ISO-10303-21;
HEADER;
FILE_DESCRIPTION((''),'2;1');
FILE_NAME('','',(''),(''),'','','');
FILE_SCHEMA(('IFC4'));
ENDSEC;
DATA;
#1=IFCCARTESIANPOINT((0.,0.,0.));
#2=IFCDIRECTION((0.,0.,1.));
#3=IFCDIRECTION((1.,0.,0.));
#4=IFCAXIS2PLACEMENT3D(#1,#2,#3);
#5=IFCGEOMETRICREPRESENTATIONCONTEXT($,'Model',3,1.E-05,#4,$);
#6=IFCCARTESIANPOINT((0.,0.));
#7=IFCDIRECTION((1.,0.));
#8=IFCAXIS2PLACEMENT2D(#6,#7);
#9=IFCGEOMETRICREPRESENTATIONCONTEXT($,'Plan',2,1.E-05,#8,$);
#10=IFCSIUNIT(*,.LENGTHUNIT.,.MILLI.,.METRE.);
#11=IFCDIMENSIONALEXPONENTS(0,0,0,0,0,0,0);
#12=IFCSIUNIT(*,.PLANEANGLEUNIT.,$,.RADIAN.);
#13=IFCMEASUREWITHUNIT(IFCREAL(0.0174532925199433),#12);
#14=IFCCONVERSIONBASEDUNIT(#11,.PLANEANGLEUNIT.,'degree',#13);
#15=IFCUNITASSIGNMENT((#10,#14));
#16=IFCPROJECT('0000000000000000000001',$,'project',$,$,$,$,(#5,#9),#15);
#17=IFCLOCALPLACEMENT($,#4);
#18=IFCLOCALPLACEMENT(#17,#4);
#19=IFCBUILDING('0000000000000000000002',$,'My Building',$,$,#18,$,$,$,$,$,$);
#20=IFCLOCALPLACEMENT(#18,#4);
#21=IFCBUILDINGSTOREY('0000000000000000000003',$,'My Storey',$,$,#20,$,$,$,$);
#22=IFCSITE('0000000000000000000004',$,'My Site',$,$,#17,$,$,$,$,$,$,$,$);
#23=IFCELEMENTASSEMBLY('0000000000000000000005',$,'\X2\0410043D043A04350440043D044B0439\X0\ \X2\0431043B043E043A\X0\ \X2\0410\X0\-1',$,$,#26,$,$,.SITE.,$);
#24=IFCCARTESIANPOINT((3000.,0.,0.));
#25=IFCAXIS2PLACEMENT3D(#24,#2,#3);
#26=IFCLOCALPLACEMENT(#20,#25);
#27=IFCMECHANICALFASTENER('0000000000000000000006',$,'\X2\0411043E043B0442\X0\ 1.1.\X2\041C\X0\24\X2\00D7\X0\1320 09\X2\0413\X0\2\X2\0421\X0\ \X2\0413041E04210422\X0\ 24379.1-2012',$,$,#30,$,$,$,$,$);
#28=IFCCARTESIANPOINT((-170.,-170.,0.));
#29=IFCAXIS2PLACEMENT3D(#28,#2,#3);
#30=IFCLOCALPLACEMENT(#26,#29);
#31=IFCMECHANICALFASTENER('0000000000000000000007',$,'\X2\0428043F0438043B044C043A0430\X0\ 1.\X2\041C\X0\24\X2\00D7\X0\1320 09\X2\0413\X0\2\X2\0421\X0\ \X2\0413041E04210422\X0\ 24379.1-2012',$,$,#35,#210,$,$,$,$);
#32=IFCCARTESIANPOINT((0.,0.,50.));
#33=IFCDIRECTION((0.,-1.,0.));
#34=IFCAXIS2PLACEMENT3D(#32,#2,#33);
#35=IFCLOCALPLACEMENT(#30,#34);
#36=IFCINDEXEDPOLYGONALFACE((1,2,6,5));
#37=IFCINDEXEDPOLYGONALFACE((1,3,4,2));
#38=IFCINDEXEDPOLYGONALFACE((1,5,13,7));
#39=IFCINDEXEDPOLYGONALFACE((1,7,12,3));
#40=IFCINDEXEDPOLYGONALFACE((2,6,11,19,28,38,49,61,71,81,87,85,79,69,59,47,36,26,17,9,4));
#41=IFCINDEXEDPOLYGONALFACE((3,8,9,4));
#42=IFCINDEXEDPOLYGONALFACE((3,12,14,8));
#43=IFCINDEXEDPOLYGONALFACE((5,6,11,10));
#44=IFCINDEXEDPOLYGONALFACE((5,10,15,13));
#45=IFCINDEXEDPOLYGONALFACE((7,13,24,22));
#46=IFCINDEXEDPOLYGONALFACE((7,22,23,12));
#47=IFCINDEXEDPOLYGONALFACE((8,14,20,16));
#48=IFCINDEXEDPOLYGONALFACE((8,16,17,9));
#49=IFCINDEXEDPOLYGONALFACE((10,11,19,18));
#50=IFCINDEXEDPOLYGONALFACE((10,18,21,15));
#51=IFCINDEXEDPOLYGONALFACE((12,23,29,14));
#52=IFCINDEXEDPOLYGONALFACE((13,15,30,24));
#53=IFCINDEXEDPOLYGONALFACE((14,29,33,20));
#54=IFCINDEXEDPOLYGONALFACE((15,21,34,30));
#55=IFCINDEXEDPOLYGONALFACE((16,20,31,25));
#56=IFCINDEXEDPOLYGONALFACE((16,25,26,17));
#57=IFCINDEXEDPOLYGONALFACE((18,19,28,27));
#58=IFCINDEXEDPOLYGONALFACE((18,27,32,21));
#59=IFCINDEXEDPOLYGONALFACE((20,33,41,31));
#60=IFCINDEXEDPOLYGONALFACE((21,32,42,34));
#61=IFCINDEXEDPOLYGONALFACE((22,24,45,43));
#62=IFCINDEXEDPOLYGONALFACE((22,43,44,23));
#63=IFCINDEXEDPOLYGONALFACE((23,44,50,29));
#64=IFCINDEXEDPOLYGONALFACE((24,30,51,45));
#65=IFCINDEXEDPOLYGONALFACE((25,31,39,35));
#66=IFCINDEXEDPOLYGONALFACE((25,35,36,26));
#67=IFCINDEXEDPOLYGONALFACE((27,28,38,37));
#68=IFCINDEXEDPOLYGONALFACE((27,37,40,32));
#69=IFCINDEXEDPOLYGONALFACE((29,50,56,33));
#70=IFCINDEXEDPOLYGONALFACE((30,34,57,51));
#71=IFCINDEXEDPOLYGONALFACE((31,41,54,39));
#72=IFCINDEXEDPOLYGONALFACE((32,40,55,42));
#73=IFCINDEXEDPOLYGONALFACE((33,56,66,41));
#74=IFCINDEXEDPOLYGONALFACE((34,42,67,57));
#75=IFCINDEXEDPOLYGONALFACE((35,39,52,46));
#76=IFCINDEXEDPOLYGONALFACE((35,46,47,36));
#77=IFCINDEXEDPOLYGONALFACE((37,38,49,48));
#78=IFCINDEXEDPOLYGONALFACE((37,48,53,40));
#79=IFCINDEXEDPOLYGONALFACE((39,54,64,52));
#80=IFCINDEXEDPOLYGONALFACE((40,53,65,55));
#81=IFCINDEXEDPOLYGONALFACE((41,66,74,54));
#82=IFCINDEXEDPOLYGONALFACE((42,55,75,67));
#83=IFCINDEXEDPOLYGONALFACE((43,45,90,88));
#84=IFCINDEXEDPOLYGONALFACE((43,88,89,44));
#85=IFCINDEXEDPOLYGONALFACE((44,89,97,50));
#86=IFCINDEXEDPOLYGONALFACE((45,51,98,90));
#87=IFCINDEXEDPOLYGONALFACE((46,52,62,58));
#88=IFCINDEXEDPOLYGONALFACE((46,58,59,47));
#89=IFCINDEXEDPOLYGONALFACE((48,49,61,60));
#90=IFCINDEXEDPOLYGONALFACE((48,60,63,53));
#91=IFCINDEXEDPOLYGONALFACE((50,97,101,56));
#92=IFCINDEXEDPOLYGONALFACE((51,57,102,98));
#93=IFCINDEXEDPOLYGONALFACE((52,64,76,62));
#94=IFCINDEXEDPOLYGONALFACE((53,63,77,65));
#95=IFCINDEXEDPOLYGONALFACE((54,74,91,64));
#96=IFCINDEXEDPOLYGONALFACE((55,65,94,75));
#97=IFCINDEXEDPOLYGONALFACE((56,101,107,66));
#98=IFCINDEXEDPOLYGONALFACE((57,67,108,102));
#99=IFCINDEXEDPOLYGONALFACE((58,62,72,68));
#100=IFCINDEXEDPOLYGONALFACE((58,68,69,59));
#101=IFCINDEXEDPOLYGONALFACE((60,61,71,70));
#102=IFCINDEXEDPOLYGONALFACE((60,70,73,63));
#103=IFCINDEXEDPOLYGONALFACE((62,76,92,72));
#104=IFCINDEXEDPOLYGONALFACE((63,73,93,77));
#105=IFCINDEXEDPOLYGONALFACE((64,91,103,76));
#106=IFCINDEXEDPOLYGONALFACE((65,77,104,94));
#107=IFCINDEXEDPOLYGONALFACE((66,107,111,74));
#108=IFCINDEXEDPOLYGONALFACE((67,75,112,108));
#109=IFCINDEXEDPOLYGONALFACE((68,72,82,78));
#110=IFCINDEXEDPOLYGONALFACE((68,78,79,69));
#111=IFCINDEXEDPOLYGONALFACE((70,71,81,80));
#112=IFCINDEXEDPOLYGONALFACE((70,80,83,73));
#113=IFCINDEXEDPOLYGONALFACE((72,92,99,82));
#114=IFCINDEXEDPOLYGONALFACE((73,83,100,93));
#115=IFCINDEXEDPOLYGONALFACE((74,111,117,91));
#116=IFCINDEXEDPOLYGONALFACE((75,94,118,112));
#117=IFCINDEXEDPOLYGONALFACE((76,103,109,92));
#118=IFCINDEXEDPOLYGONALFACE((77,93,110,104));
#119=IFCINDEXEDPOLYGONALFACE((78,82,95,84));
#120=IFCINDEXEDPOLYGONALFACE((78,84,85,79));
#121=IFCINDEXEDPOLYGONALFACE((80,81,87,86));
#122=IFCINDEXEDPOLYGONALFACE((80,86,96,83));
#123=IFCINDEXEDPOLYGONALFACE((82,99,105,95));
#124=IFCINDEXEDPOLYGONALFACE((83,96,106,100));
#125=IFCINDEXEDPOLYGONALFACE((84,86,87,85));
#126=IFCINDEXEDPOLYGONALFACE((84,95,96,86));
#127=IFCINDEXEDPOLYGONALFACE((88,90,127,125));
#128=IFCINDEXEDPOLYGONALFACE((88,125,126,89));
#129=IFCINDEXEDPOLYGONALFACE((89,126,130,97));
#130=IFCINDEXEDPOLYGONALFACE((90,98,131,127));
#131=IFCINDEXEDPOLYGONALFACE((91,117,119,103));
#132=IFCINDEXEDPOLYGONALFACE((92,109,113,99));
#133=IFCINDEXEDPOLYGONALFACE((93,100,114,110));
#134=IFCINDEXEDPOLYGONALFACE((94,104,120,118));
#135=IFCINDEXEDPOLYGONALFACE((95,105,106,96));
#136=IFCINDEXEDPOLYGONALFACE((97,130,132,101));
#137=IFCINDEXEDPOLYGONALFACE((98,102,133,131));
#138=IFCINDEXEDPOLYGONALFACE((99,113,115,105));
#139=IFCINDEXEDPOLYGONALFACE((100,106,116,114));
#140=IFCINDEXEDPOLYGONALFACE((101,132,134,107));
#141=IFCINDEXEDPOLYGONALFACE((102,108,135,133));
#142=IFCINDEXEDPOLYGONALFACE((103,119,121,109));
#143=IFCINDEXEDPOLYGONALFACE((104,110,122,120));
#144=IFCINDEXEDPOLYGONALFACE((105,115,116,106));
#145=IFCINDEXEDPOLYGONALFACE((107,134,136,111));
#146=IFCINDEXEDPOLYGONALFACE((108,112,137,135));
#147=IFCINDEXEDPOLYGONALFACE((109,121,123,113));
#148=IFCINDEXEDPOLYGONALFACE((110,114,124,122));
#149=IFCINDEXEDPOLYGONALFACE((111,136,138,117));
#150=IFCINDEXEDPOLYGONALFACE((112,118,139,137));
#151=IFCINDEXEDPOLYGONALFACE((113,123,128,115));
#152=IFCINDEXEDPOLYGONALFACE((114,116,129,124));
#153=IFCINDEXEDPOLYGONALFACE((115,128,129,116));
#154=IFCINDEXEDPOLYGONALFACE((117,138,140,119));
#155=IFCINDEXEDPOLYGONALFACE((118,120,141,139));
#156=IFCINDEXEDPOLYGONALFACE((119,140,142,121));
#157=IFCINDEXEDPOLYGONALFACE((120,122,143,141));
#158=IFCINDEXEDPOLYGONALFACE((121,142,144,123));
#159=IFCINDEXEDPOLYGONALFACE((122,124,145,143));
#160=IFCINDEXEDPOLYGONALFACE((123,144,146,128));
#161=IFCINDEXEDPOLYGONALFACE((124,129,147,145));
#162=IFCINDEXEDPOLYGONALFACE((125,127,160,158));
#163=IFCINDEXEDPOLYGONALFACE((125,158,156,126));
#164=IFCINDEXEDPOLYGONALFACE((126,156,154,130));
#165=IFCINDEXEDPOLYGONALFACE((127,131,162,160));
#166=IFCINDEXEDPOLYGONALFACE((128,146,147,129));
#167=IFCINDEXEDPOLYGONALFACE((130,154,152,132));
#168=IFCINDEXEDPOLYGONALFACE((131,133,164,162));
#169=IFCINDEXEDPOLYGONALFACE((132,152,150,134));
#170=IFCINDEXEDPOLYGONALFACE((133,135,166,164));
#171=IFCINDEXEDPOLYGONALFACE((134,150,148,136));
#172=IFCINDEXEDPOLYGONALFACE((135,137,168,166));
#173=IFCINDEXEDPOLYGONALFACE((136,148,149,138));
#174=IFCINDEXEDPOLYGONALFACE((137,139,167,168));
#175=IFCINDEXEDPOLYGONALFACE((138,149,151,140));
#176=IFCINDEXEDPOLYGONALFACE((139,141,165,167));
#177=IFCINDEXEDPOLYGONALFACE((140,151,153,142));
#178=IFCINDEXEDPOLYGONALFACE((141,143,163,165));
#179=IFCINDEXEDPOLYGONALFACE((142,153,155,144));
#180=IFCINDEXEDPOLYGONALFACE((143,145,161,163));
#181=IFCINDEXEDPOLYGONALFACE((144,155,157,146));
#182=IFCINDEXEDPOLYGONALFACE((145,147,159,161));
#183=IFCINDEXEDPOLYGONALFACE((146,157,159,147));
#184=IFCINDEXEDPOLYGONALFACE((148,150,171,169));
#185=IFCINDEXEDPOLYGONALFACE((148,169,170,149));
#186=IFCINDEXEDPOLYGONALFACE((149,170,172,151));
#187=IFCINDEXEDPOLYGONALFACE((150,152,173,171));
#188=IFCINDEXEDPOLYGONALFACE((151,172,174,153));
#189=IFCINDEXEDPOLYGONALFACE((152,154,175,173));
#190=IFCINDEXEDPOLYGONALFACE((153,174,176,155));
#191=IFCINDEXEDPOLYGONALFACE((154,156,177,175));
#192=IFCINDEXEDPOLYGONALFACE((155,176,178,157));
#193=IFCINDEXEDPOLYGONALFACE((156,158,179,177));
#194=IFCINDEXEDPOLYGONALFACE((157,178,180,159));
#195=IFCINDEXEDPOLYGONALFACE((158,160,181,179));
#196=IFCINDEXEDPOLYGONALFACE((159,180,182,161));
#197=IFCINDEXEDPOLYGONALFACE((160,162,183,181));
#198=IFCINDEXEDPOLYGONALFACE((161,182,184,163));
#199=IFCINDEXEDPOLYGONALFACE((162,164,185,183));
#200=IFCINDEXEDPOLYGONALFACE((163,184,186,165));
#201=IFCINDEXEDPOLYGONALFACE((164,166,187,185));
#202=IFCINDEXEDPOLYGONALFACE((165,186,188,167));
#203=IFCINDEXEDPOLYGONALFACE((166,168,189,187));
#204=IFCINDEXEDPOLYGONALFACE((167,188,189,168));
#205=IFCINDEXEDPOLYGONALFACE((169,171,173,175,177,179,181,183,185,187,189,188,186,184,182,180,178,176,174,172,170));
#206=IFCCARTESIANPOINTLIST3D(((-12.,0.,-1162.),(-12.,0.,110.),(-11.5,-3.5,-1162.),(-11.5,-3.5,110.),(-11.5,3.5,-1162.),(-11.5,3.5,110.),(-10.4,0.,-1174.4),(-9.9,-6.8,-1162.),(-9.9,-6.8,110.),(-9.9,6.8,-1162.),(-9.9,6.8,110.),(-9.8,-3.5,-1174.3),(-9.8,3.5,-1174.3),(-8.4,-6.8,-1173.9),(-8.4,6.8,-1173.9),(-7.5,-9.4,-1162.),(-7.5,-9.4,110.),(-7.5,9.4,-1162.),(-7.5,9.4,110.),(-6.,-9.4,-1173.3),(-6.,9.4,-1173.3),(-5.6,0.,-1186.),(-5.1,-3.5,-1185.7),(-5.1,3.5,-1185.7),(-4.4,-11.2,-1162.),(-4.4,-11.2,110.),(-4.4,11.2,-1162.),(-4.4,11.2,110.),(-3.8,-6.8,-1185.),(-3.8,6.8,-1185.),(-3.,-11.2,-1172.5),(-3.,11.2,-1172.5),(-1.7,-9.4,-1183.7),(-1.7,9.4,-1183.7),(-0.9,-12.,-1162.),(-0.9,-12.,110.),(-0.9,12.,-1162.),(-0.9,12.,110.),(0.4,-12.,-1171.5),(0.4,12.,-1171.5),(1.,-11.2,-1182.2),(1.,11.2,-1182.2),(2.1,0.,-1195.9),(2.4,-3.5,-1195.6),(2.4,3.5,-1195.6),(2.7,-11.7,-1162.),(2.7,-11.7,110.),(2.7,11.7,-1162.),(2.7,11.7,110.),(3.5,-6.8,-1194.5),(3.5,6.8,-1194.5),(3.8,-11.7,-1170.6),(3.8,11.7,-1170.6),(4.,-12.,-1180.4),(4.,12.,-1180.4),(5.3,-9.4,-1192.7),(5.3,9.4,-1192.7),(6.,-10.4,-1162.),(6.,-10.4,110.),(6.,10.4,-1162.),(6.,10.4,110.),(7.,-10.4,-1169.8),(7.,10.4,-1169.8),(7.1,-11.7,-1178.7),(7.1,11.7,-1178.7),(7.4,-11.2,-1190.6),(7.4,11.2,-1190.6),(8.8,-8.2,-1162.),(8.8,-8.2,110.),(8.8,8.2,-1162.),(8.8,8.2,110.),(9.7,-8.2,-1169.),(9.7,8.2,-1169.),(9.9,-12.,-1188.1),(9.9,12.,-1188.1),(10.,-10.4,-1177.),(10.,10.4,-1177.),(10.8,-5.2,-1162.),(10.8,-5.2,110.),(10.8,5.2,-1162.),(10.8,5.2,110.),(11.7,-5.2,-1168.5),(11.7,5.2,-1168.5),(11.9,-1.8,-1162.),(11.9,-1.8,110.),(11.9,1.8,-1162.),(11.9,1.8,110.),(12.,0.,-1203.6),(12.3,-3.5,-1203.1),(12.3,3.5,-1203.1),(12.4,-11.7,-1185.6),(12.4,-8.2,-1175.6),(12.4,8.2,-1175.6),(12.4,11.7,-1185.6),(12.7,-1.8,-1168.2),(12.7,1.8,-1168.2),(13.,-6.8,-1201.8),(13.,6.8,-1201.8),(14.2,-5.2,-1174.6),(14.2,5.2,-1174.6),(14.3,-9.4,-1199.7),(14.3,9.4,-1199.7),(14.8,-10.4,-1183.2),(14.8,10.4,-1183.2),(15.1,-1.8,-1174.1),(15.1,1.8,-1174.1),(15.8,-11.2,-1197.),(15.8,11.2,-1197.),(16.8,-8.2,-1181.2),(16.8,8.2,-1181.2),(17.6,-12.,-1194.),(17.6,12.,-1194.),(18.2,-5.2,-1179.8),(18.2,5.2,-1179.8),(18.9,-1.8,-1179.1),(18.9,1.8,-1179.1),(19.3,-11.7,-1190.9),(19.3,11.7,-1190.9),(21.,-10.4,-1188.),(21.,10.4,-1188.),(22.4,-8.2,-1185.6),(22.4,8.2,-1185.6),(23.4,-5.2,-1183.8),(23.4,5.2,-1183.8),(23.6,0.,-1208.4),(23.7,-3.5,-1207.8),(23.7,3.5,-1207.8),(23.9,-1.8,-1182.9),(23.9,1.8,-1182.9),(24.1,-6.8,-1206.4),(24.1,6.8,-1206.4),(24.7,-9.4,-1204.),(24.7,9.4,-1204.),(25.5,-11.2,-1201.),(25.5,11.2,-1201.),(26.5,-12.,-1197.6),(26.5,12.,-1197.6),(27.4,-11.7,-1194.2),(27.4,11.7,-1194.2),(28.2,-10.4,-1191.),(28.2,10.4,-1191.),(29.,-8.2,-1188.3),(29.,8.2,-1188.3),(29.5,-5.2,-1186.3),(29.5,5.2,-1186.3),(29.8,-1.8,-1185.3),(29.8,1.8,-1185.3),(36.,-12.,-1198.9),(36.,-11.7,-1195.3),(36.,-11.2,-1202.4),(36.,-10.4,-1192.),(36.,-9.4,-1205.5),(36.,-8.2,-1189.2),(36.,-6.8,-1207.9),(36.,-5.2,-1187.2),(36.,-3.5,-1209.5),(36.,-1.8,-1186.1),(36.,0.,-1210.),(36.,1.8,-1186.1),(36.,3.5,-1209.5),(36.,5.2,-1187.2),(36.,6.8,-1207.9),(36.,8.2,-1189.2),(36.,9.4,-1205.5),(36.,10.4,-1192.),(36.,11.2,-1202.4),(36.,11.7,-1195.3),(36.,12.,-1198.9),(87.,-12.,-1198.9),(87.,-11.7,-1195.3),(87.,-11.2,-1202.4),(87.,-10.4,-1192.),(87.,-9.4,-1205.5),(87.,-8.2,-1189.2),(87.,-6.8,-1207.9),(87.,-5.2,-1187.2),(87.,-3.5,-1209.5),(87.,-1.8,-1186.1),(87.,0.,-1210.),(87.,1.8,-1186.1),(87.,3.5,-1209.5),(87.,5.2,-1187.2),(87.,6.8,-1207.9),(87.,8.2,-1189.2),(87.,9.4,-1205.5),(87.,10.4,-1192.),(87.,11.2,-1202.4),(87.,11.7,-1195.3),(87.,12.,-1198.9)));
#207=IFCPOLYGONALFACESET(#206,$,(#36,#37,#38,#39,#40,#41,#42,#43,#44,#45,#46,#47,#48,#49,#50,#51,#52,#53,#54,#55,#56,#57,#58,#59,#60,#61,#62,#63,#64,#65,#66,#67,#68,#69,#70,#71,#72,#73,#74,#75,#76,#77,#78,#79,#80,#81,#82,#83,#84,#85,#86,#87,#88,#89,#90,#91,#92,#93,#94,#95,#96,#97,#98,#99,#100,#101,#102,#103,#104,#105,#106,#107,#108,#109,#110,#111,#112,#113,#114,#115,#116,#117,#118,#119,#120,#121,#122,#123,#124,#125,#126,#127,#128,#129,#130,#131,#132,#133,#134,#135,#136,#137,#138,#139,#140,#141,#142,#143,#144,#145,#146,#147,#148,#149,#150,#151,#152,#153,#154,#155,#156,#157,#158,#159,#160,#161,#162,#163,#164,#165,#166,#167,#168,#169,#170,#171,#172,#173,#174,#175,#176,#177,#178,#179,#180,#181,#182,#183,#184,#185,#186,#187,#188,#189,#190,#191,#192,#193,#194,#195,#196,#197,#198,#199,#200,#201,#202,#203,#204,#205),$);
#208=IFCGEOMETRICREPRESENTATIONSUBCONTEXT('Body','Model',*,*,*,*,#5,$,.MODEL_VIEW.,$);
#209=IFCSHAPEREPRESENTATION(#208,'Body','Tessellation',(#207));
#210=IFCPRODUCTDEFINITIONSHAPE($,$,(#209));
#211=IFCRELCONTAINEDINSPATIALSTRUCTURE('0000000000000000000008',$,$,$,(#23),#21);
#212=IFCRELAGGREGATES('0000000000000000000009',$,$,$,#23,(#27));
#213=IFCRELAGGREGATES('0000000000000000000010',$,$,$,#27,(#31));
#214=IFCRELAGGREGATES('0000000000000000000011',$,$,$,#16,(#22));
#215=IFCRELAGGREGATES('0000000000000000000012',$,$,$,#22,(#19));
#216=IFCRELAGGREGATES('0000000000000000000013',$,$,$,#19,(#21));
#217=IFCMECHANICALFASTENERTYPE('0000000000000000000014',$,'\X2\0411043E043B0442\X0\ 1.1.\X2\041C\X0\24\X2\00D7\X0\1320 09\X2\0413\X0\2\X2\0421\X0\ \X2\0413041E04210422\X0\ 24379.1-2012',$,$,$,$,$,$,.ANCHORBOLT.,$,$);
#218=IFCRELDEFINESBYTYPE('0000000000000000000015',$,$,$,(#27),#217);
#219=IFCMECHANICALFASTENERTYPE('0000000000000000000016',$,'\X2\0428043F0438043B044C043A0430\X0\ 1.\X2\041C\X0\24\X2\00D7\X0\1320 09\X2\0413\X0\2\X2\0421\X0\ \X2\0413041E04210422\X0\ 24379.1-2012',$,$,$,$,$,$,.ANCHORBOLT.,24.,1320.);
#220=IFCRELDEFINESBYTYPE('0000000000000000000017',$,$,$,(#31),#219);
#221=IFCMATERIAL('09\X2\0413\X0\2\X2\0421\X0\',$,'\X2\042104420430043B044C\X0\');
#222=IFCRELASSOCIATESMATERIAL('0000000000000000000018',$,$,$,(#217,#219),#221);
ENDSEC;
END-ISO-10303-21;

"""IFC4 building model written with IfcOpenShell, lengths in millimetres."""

from ifc_helpers import new_model, entity, si_unit, converted_unit, frame, origin_with_axes, origin_2d_with_axis, place, context, subcontext, project, spatial, source, transform, mapped, material, type_object, type_shapes, element, aggregate, save


model = new_model("IFC4")

# Units and contexts
model_context = context("Model", 3, precision=1e-05, world=origin_with_axes())
plan_context = context("Plan", 2, precision=1e-05, world=origin_2d_with_axis())
body_context = subcontext(model_context, "Body", "Model", "MODEL_VIEW")
ifc_project = project(units=[si_unit("LENGTHUNIT", "METRE", prefix="MILLI"), converted_unit("PLANEANGLEUNIT", "degree", entity("IfcReal", 0.0174532925199433), si_unit("PLANEANGLEUNIT", "RADIAN"), dimensions=[0, 0, 0, 0, 0, 0, 0])], contexts=[model_context, plan_context])

# Site, building, storey
site_placement = place(None, origin_with_axes())
site = spatial("IfcSite", under=ifc_project, at=site_placement, Name="My Site")
building_placement = place(site_placement, origin_with_axes())
building = spatial("IfcBuilding", under=site, at=building_placement, Name="My Building")
storey_placement = place(building_placement, origin_with_axes())
storey = spatial("IfcBuildingStorey", under=building, at=storey_placement, Name="My Storey")

# Element assembly
placement_1 = place(storey_placement, frame((3000.0, 0.0, 0.0), z_axis=(0.0, 0.0, 1.0), x_axis=(1.0, 0.0, 0.0)))
assembly_1 = element("IfcElementAssembly", 1, at=placement_1, inside=storey, Name="Анкерный блок А-1", AssemblyPlace="SITE")

# Shared definitions
ifc_material_1 = material(Name="09Г2С", Category="Сталь")
mechanical_fastener_type_1 = type_object("IfcMechanicalFastenerType", Name="Болт 1.1.М24×1320 09Г2С ГОСТ 24379.1-2012", PredefinedType="ANCHORBOLT", material=ifc_material_1)
mechanical_fastener_type_2 = type_object("IfcMechanicalFastenerType", Name="Шпилька 1.М24×1320 09Г2С ГОСТ 24379.1-2012", NominalDiameter=24.0, NominalLength=1320.0, PredefinedType="ANCHORBOLT", material=ifc_material_1)
shared_shape_1 = source(frame((0.0, 0.0, 110.0), z_axis=(0.0, 0.0, 1.0), x_axis=(1.0, 0.0, 0.0)), body_context, "Body", "AdvancedSweptSolid", [
    entity("IfcSweptDiskSolid", entity("IfcIndexedPolyCurve", entity("IfcCartesianPointList3D", [[0.0, 0.0, 0.0], [0.0, 0.0, -1272.0], [10.5, 0.0, -1297.5], [36.0, 0.0, -1308.0], [87.0, 0.0, -1308.0]]), [entity("IfcLineIndex", [1, 2]), entity("IfcArcIndex", [2, 3, 4]), entity("IfcLineIndex", [4, 5])]), 12.0),
])
type_shapes(mechanical_fastener_type_2, [shared_shape_1])

# Mechanical fasteners
mechanical_fastener_1_placement = place(placement_1, frame((-170.0, -170.0, 0.0), z_axis=(0.0, 0.0, 1.0), x_axis=(1.0, 0.0, 0.0)))
mechanical_fastener_1 = element("IfcMechanicalFastener", 2, at=mechanical_fastener_1_placement, type_object=mechanical_fastener_type_1, Name="Болт 1.1.М24×1320 09Г2С ГОСТ 24379.1-2012")
mechanical_fastener_2_placement = place(mechanical_fastener_1_placement, frame((0.0, 0.0, 50.0), z_axis=(0.0, 0.0, 1.0), x_axis=(0.0, -1.0, 0.0)))
mechanical_fastener_2 = element("IfcMechanicalFastener", 3, at=mechanical_fastener_2_placement, type_object=mechanical_fastener_type_2, Name="Шпилька 1.М24×1320 09Г2С ГОСТ 24379.1-2012", context=body_context, shape_type="MappedRepresentation", body=[
    mapped(shared_shape_1, transform((0.0, 0.0, 0.0), x_axis=(1.0, 0.0, 0.0), y_axis=(0.0, 1.0, 0.0), z_axis=(0.0, 0.0, 1.0), scale=1.0)),
])

aggregate(assembly_1, [mechanical_fastener_1])
aggregate(mechanical_fastener_1, [mechanical_fastener_2])

save(model, "model.ifc")
